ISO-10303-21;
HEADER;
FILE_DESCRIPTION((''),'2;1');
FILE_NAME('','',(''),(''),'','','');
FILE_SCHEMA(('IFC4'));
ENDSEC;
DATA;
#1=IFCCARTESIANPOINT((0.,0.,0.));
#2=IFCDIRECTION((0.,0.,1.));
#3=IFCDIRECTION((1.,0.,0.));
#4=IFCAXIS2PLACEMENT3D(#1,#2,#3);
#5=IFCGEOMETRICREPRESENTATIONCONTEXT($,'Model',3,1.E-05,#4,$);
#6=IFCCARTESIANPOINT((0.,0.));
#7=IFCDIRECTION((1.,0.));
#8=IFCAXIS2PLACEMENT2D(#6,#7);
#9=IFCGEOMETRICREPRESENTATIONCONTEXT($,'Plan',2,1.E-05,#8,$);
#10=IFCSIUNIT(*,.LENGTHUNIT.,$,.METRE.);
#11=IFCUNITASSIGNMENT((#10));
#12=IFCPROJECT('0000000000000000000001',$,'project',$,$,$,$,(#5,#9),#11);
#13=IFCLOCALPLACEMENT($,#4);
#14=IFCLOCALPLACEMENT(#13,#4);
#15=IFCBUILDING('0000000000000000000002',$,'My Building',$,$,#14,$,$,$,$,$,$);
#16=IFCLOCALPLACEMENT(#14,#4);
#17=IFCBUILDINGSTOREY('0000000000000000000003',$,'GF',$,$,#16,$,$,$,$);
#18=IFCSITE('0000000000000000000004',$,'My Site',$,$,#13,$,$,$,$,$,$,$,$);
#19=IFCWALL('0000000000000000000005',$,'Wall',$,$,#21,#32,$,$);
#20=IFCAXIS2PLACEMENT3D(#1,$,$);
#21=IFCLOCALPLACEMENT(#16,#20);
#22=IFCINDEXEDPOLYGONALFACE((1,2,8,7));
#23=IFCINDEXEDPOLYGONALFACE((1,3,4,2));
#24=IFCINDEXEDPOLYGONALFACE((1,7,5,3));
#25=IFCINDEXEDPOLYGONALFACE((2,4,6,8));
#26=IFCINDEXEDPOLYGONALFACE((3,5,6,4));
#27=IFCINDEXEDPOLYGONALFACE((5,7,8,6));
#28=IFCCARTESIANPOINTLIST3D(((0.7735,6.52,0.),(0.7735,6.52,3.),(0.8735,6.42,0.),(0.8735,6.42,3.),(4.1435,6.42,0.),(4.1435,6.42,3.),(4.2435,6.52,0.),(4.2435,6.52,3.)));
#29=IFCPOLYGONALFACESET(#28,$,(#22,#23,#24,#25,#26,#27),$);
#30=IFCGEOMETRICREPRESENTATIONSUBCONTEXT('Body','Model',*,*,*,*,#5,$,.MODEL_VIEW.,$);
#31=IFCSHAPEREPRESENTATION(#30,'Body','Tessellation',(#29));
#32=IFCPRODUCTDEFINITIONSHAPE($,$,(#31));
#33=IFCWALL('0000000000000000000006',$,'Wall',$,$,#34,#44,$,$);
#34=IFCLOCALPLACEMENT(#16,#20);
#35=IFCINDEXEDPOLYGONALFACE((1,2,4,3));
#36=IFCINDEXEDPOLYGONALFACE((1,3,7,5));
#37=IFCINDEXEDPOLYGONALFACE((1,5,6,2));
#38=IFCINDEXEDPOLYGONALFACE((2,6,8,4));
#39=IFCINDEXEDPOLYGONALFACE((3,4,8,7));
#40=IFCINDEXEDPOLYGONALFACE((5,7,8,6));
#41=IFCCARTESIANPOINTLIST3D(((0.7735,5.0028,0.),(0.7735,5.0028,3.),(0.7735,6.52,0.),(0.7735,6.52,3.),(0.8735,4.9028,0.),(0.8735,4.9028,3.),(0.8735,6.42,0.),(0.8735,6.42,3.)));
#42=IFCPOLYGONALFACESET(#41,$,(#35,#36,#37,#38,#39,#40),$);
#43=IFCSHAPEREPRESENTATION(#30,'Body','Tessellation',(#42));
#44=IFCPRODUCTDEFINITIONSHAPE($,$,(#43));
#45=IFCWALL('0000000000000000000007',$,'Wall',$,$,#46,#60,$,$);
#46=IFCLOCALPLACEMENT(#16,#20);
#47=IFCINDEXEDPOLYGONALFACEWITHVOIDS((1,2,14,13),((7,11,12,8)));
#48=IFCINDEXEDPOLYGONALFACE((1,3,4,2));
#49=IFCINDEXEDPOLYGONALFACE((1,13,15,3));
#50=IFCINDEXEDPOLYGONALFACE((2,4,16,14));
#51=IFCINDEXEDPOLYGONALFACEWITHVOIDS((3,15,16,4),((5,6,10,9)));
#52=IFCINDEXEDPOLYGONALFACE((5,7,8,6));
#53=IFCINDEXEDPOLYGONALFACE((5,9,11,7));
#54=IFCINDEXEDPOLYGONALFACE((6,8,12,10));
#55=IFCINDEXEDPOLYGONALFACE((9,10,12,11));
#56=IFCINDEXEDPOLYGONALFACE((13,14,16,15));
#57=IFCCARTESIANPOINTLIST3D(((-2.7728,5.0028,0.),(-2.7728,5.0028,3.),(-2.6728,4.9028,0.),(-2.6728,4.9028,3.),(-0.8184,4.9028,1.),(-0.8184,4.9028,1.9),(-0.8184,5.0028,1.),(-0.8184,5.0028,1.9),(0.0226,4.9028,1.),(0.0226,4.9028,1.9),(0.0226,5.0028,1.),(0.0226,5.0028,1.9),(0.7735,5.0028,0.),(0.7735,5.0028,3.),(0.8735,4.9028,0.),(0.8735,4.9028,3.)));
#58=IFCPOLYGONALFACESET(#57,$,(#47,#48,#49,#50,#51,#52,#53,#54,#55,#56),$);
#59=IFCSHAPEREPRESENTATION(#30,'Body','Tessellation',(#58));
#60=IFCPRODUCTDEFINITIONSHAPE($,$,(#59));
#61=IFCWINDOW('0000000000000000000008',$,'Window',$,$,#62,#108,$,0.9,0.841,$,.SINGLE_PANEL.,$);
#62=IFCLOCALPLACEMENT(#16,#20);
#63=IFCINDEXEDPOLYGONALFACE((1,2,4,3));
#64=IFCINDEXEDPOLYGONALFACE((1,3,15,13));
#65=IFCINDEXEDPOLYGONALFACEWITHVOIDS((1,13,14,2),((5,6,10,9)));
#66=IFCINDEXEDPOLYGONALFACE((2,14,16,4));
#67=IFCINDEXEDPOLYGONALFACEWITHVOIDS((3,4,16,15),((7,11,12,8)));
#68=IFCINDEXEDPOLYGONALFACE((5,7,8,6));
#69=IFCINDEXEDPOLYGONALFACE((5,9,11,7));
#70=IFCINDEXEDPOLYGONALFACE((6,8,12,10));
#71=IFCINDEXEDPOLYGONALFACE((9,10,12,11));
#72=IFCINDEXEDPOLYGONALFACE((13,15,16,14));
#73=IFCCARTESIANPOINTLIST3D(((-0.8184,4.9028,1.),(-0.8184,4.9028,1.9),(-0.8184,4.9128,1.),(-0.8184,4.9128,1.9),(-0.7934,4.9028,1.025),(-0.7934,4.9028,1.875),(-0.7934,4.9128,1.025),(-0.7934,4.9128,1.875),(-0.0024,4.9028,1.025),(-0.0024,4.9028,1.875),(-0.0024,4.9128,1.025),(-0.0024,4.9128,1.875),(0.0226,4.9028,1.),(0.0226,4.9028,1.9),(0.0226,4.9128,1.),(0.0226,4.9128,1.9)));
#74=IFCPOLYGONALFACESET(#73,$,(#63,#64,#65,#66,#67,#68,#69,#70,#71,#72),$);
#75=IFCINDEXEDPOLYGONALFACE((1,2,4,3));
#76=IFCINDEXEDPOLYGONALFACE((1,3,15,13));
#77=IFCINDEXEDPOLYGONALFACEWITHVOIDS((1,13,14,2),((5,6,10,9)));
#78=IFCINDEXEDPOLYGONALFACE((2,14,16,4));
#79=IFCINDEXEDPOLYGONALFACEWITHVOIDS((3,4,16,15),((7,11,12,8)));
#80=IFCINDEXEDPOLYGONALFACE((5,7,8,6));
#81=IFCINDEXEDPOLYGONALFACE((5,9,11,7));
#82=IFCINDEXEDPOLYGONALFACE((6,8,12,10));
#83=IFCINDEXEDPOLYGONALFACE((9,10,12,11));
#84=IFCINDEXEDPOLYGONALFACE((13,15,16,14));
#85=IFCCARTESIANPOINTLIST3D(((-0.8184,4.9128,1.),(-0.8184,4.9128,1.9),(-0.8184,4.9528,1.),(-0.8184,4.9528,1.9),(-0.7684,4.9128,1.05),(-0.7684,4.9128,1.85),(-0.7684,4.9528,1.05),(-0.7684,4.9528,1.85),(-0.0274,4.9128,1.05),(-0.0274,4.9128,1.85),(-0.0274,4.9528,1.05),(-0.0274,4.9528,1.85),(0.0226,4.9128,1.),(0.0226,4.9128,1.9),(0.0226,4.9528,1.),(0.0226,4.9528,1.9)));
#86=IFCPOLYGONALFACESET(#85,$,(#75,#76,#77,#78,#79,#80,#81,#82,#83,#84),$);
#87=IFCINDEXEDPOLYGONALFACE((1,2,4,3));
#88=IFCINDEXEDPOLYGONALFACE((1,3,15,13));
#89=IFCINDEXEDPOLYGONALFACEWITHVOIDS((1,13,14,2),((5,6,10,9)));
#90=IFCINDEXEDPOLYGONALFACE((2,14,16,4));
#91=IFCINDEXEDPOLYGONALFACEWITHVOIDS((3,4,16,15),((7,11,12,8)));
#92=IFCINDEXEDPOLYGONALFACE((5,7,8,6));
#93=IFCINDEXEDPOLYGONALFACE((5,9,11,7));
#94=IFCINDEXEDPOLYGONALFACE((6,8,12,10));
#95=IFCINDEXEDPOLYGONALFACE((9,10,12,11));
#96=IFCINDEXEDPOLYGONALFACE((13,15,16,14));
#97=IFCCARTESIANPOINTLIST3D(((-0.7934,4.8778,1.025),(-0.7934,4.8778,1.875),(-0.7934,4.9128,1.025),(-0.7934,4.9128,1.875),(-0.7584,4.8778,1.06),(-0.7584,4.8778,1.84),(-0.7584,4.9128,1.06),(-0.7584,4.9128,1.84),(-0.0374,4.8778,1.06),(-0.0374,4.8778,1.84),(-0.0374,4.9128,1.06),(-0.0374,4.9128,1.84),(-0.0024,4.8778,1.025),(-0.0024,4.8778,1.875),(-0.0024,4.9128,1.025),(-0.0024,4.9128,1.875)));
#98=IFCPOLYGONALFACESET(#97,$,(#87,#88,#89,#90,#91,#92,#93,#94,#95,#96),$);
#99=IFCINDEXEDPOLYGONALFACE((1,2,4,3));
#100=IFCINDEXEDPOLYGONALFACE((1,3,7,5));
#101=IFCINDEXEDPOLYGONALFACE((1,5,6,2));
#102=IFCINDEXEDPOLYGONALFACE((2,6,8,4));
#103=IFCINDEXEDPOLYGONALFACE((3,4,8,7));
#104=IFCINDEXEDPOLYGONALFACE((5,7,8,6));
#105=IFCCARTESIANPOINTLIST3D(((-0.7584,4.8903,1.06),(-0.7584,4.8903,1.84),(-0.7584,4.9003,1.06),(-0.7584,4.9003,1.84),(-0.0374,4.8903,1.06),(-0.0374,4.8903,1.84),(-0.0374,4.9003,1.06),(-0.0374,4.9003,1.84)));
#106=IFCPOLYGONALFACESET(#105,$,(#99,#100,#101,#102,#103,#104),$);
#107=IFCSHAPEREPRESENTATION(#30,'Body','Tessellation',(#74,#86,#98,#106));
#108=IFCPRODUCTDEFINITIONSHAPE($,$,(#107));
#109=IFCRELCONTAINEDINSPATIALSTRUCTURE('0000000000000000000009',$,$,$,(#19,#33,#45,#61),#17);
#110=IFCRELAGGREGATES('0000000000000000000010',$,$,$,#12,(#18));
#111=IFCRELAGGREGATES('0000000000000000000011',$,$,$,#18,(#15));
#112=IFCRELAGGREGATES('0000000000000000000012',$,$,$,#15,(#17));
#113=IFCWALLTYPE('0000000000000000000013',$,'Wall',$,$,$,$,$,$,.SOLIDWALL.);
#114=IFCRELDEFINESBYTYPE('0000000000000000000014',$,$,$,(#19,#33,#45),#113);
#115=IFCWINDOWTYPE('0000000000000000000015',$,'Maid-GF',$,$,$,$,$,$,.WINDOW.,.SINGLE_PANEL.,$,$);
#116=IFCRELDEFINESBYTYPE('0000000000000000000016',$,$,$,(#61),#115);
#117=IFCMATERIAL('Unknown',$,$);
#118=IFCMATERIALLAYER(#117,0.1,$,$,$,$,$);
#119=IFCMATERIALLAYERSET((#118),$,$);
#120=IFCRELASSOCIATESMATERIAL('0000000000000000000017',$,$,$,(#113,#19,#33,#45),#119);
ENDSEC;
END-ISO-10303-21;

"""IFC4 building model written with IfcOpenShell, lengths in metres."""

from ifc_helpers import new_model, entity, si_unit, frame, origin_with_axes, origin_2d_with_axis, place, context, subcontext, project, spatial, line, indexed_curve, outline, extrude, shape, source, transform, mapped, material, layer, layer_set, layer_usage, type_object, type_shapes, element, fill, save


model = new_model("IFC4")

# Units and contexts
model_context = context("Model", 3, precision=1e-05, world=origin_with_axes())
plan_context = context("Plan", 2, precision=1e-05, world=origin_2d_with_axis())
body_context_1 = subcontext(model_context, "Body", "Model", "MODEL_VIEW")
body_context_2 = subcontext(plan_context, "Body", "Plan", "PLAN_VIEW")
ifc_project = project(units=[si_unit("LENGTHUNIT", "METRE")], contexts=[model_context, plan_context])

# Site, building, storey
site_placement = place(None, origin_with_axes())
site = spatial("IfcSite", under=ifc_project, at=site_placement, Name="My Site")
building_placement = place(site_placement, origin_with_axes())
building = spatial("IfcBuilding", under=site, at=building_placement, Name="My Building")
storey_placement = place(building_placement, origin_with_axes())
storey = spatial("IfcBuildingStorey", under=building, at=storey_placement, Name="GF")

# Shared definitions
ifc_material_1 = material(Name="Unknown")

# Walls
ifc_layer_1 = layer(ifc_material_1, 0.1)
ifc_layer_set_1 = layer_set([ifc_layer_1])
ifc_layer_usage_1 = layer_usage(ifc_layer_set_1, "AXIS2", "POSITIVE", 0.0)
wall_type = type_object("IfcWallType", Name="Wall", PredefinedType="SOLIDWALL", material=ifc_layer_set_1)
wall_1_placement = place(storey_placement, frame((4.2435, 6.52, 0.0), z_axis=(0.0, 0.0, 1.0), x_axis=(-1.0, 0.0, 0.0)))
element("IfcWall", 1, at=wall_1_placement, inside=storey, type_object=wall_type, material=ifc_layer_usage_1, Name="Wall", context=body_context_1, shape_type="SweptSolid", body=[
    extrude(outline(indexed_curve([(0.0, 0.0), (0.1, 0.1), (3.37, 0.1), (3.47, 0.0)], segments=[line(1, 2, 3, 4, 1)])), origin_with_axes(), (0.0, 0.0, 1.0), 3.0),
])
ifc_layer_usage_2 = layer_usage(ifc_layer_set_1, "AXIS2", "POSITIVE", 0.0)
wall_2_placement = place(storey_placement, frame((0.7735, 6.52, 0.0), z_axis=(0.0, 0.0, 1.0), x_axis=(0.0, -1.0, 0.0)))
element("IfcWall", 2, at=wall_2_placement, inside=storey, type_object=wall_type, material=ifc_layer_usage_2, Name="Wall", context=body_context_1, shape_type="SweptSolid", body=[
    extrude(outline(indexed_curve([(0.0, 0.0), (0.1, 0.1), (1.6172, 0.1), (1.5172, 0.0)], segments=[line(1, 2, 3, 4, 1)])), origin_with_axes(), (0.0, 0.0, 1.0), 3.0),
])

# Wall, opening, window
ifc_layer_usage_3 = layer_usage(ifc_layer_set_1, "AXIS2", "POSITIVE", 0.0)
wall_3_placement = place(storey_placement, frame((0.7735, 5.0028, 0.0), z_axis=(0.0, 0.0, 1.0), x_axis=(-1.0, 0.0, 0.0)))
wall_3 = element("IfcWall", 3, at=wall_3_placement, inside=storey, type_object=wall_type, material=ifc_layer_usage_3, Name="Wall", context=body_context_1, shape_type="SweptSolid", body=[
    extrude(outline(indexed_curve([(0.0, 0.0), (-0.1, 0.1), (3.4463, 0.1), (3.5463, 0.0)], segments=[line(1, 2, 3, 4, 1)])), origin_with_axes(), (0.0, 0.0, 1.0), 3.0),
])
shared_shape_1 = source(origin_with_axes(), body_context_1, "Body", "SweptSolid", [
    extrude(outline(indexed_curve([(0.0, 0.0), (0.841, 0.0), (0.841, 0.9), (0.0, 0.9)], segments=[line(1, 2, 3, 4, 1)])), frame((0.0, -0.6, 0.0), z_axis=(0.0, -1.0, 0.0), x_axis=(1.0, 0.0, 0.0)), (0.0, 0.0, -1.0), 1.2),
])
opening_1_placement = place(wall_3_placement, frame((0.7509, 0.0, 1.0), z_axis=(0.0, 0.0, 1.0), x_axis=(1.0, 0.0, 0.0)))
opening_1 = element("IfcOpeningElement", 4, at=opening_1_placement, cuts=wall_3, PredefinedType="OPENING", context=body_context_1, shape_type="MappedRepresentation", body=[
    mapped(shared_shape_1, transform((0.0, 0.0, 0.0), x_axis=(1.0, 0.0, 0.0), y_axis=(0.0, 1.0, 0.0), z_axis=(0.0, 0.0, 1.0), scale=1.0)),
])
window_type_1 = type_object("IfcWindowType", Name="Maid-GF", PartitioningType="SINGLE_PANEL", PredefinedType="WINDOW")
shared_shape_2 = source(origin_with_axes(), body_context_1, "Body", "SweptSolid", [
    extrude(outline(indexed_curve([(0.0, 0.0), (0.841, 0.0), (0.841, 0.9), (0.0, 0.9)], segments=[line(1, 2, 3, 4, 1)]), holes=[indexed_curve([(0.025, 0.025), (0.816, 0.025), (0.816, 0.875), (0.025, 0.875)], segments=[line(1, 2, 3, 4, 1)])]), frame((0.0, 0.09, 0.0), z_axis=(0.0, -1.0, 0.0), x_axis=(1.0, 0.0, 0.0)), (0.0, 0.0, -1.0), 0.01),
    extrude(outline(indexed_curve([(0.0, 0.0), (0.841, 0.0), (0.841, 0.9), (0.0, 0.9)], segments=[line(1, 2, 3, 4, 1)]), holes=[indexed_curve([(0.05, 0.05), (0.791, 0.05), (0.791, 0.85), (0.05, 0.85)], segments=[line(1, 2, 3, 4, 1)])]), frame((0.0, 0.05, 0.0), z_axis=(0.0, -1.0, 0.0), x_axis=(1.0, 0.0, 0.0)), (0.0, 0.0, -1.0), 0.04),
    extrude(outline(indexed_curve([(0.0, 0.0), (0.791, 0.0), (0.791, 0.85), (0.0, 0.85)], segments=[line(1, 2, 3, 4, 1)]), holes=[indexed_curve([(0.035, 0.035), (0.756, 0.035), (0.756, 0.815), (0.035, 0.815)], segments=[line(1, 2, 3, 4, 1)])]), frame((0.025, 0.09, 0.025), z_axis=(0.0, -1.0, 0.0), x_axis=(1.0, 0.0, 0.0)), (0.0, 0.0, -1.0), 0.035),
    extrude(outline(indexed_curve([(0.035, 0.035), (0.756, 0.035), (0.756, 0.815), (0.035, 0.815)], segments=[line(1, 2, 3, 4, 1)])), frame((0.025, 0.1025, 0.025), z_axis=(0.0, -1.0, 0.0), x_axis=(1.0, 0.0, 0.0)), (0.0, 0.0, -1.0), 0.01),
])
shared_shape_3 = source(origin_with_axes(), body_context_2, "Body", "Curve2D", [
    entity("IfcIndexedPolyCurve", entity("IfcCartesianPointList2D", [[0.05, 0.05], [0.791, 0.05]])),
    entity("IfcIndexedPolyCurve", entity("IfcCartesianPointList2D", [[0.0, 0.1], [0.025, 0.1], [0.025, 0.09], [0.05, 0.09], [0.05, 0.05], [0.0, 0.05]]), [entity("IfcLineIndex", [1, 2, 3, 4, 5, 6, 1])]),
    entity("IfcIndexedPolyCurve", entity("IfcCartesianPointList2D", [[0.841, 0.1], [0.816, 0.1], [0.816, 0.09], [0.791, 0.09], [0.791, 0.05], [0.841, 0.05]]), [entity("IfcLineIndex", [1, 2, 3, 4, 5, 6, 1])]),
    entity("IfcIndexedPolyCurve", entity("IfcCartesianPointList2D", [[0.025, 0.09], [0.06, 0.09], [0.06, 0.125], [0.025, 0.125]]), [entity("IfcLineIndex", [1, 2, 3, 4, 1])]),
    entity("IfcIndexedPolyCurve", entity("IfcCartesianPointList2D", [[0.816, 0.09], [0.781, 0.09], [0.781, 0.125], [0.816, 0.125]]), [entity("IfcLineIndex", [1, 2, 3, 4, 1])]),
    entity("IfcIndexedPolyCurve", entity("IfcCartesianPointList2D", [[0.06, 0.09], [0.781, 0.09]])),
    entity("IfcIndexedPolyCurve", entity("IfcCartesianPointList2D", [[0.06, 0.125], [0.781, 0.125]])),
    entity("IfcIndexedPolyCurve", entity("IfcCartesianPointList2D", [[0.06, 0.1075], [0.781, 0.1075]])),
])
type_shapes(window_type_1, [shared_shape_2, shared_shape_3])
window_1_placement = place(opening_1_placement, frame((0.0, 0.0, 0.0), z_axis=(0.0, 0.0, 1.0), x_axis=(1.0, 0.0, 0.0)))
window_1 = element("IfcWindow", 5, at=window_1_placement, inside=storey, type_object=window_type_1, Name="Window", OverallHeight=0.9, OverallWidth=0.841, PartitioningType="SINGLE_PANEL", shapes=[
    shape(body_context_1, "Body", "MappedRepresentation", [mapped(shared_shape_2, transform((0.0, 0.0, 0.0), x_axis=(1.0, 0.0, 0.0), y_axis=(0.0, 1.0, 0.0), z_axis=(0.0, 0.0, 1.0), scale=1.0))]),
    shape(body_context_2, "Body", "MappedRepresentation", [mapped(shared_shape_3, transform((0.0, 0.0, 0.0), x_axis=(1.0, 0.0, 0.0), y_axis=(0.0, 1.0, 0.0), z_axis=(0.0, 0.0, 1.0), scale=1.0))]),
])
fill(opening_1, window_1)

save(model, "model.ifc")
